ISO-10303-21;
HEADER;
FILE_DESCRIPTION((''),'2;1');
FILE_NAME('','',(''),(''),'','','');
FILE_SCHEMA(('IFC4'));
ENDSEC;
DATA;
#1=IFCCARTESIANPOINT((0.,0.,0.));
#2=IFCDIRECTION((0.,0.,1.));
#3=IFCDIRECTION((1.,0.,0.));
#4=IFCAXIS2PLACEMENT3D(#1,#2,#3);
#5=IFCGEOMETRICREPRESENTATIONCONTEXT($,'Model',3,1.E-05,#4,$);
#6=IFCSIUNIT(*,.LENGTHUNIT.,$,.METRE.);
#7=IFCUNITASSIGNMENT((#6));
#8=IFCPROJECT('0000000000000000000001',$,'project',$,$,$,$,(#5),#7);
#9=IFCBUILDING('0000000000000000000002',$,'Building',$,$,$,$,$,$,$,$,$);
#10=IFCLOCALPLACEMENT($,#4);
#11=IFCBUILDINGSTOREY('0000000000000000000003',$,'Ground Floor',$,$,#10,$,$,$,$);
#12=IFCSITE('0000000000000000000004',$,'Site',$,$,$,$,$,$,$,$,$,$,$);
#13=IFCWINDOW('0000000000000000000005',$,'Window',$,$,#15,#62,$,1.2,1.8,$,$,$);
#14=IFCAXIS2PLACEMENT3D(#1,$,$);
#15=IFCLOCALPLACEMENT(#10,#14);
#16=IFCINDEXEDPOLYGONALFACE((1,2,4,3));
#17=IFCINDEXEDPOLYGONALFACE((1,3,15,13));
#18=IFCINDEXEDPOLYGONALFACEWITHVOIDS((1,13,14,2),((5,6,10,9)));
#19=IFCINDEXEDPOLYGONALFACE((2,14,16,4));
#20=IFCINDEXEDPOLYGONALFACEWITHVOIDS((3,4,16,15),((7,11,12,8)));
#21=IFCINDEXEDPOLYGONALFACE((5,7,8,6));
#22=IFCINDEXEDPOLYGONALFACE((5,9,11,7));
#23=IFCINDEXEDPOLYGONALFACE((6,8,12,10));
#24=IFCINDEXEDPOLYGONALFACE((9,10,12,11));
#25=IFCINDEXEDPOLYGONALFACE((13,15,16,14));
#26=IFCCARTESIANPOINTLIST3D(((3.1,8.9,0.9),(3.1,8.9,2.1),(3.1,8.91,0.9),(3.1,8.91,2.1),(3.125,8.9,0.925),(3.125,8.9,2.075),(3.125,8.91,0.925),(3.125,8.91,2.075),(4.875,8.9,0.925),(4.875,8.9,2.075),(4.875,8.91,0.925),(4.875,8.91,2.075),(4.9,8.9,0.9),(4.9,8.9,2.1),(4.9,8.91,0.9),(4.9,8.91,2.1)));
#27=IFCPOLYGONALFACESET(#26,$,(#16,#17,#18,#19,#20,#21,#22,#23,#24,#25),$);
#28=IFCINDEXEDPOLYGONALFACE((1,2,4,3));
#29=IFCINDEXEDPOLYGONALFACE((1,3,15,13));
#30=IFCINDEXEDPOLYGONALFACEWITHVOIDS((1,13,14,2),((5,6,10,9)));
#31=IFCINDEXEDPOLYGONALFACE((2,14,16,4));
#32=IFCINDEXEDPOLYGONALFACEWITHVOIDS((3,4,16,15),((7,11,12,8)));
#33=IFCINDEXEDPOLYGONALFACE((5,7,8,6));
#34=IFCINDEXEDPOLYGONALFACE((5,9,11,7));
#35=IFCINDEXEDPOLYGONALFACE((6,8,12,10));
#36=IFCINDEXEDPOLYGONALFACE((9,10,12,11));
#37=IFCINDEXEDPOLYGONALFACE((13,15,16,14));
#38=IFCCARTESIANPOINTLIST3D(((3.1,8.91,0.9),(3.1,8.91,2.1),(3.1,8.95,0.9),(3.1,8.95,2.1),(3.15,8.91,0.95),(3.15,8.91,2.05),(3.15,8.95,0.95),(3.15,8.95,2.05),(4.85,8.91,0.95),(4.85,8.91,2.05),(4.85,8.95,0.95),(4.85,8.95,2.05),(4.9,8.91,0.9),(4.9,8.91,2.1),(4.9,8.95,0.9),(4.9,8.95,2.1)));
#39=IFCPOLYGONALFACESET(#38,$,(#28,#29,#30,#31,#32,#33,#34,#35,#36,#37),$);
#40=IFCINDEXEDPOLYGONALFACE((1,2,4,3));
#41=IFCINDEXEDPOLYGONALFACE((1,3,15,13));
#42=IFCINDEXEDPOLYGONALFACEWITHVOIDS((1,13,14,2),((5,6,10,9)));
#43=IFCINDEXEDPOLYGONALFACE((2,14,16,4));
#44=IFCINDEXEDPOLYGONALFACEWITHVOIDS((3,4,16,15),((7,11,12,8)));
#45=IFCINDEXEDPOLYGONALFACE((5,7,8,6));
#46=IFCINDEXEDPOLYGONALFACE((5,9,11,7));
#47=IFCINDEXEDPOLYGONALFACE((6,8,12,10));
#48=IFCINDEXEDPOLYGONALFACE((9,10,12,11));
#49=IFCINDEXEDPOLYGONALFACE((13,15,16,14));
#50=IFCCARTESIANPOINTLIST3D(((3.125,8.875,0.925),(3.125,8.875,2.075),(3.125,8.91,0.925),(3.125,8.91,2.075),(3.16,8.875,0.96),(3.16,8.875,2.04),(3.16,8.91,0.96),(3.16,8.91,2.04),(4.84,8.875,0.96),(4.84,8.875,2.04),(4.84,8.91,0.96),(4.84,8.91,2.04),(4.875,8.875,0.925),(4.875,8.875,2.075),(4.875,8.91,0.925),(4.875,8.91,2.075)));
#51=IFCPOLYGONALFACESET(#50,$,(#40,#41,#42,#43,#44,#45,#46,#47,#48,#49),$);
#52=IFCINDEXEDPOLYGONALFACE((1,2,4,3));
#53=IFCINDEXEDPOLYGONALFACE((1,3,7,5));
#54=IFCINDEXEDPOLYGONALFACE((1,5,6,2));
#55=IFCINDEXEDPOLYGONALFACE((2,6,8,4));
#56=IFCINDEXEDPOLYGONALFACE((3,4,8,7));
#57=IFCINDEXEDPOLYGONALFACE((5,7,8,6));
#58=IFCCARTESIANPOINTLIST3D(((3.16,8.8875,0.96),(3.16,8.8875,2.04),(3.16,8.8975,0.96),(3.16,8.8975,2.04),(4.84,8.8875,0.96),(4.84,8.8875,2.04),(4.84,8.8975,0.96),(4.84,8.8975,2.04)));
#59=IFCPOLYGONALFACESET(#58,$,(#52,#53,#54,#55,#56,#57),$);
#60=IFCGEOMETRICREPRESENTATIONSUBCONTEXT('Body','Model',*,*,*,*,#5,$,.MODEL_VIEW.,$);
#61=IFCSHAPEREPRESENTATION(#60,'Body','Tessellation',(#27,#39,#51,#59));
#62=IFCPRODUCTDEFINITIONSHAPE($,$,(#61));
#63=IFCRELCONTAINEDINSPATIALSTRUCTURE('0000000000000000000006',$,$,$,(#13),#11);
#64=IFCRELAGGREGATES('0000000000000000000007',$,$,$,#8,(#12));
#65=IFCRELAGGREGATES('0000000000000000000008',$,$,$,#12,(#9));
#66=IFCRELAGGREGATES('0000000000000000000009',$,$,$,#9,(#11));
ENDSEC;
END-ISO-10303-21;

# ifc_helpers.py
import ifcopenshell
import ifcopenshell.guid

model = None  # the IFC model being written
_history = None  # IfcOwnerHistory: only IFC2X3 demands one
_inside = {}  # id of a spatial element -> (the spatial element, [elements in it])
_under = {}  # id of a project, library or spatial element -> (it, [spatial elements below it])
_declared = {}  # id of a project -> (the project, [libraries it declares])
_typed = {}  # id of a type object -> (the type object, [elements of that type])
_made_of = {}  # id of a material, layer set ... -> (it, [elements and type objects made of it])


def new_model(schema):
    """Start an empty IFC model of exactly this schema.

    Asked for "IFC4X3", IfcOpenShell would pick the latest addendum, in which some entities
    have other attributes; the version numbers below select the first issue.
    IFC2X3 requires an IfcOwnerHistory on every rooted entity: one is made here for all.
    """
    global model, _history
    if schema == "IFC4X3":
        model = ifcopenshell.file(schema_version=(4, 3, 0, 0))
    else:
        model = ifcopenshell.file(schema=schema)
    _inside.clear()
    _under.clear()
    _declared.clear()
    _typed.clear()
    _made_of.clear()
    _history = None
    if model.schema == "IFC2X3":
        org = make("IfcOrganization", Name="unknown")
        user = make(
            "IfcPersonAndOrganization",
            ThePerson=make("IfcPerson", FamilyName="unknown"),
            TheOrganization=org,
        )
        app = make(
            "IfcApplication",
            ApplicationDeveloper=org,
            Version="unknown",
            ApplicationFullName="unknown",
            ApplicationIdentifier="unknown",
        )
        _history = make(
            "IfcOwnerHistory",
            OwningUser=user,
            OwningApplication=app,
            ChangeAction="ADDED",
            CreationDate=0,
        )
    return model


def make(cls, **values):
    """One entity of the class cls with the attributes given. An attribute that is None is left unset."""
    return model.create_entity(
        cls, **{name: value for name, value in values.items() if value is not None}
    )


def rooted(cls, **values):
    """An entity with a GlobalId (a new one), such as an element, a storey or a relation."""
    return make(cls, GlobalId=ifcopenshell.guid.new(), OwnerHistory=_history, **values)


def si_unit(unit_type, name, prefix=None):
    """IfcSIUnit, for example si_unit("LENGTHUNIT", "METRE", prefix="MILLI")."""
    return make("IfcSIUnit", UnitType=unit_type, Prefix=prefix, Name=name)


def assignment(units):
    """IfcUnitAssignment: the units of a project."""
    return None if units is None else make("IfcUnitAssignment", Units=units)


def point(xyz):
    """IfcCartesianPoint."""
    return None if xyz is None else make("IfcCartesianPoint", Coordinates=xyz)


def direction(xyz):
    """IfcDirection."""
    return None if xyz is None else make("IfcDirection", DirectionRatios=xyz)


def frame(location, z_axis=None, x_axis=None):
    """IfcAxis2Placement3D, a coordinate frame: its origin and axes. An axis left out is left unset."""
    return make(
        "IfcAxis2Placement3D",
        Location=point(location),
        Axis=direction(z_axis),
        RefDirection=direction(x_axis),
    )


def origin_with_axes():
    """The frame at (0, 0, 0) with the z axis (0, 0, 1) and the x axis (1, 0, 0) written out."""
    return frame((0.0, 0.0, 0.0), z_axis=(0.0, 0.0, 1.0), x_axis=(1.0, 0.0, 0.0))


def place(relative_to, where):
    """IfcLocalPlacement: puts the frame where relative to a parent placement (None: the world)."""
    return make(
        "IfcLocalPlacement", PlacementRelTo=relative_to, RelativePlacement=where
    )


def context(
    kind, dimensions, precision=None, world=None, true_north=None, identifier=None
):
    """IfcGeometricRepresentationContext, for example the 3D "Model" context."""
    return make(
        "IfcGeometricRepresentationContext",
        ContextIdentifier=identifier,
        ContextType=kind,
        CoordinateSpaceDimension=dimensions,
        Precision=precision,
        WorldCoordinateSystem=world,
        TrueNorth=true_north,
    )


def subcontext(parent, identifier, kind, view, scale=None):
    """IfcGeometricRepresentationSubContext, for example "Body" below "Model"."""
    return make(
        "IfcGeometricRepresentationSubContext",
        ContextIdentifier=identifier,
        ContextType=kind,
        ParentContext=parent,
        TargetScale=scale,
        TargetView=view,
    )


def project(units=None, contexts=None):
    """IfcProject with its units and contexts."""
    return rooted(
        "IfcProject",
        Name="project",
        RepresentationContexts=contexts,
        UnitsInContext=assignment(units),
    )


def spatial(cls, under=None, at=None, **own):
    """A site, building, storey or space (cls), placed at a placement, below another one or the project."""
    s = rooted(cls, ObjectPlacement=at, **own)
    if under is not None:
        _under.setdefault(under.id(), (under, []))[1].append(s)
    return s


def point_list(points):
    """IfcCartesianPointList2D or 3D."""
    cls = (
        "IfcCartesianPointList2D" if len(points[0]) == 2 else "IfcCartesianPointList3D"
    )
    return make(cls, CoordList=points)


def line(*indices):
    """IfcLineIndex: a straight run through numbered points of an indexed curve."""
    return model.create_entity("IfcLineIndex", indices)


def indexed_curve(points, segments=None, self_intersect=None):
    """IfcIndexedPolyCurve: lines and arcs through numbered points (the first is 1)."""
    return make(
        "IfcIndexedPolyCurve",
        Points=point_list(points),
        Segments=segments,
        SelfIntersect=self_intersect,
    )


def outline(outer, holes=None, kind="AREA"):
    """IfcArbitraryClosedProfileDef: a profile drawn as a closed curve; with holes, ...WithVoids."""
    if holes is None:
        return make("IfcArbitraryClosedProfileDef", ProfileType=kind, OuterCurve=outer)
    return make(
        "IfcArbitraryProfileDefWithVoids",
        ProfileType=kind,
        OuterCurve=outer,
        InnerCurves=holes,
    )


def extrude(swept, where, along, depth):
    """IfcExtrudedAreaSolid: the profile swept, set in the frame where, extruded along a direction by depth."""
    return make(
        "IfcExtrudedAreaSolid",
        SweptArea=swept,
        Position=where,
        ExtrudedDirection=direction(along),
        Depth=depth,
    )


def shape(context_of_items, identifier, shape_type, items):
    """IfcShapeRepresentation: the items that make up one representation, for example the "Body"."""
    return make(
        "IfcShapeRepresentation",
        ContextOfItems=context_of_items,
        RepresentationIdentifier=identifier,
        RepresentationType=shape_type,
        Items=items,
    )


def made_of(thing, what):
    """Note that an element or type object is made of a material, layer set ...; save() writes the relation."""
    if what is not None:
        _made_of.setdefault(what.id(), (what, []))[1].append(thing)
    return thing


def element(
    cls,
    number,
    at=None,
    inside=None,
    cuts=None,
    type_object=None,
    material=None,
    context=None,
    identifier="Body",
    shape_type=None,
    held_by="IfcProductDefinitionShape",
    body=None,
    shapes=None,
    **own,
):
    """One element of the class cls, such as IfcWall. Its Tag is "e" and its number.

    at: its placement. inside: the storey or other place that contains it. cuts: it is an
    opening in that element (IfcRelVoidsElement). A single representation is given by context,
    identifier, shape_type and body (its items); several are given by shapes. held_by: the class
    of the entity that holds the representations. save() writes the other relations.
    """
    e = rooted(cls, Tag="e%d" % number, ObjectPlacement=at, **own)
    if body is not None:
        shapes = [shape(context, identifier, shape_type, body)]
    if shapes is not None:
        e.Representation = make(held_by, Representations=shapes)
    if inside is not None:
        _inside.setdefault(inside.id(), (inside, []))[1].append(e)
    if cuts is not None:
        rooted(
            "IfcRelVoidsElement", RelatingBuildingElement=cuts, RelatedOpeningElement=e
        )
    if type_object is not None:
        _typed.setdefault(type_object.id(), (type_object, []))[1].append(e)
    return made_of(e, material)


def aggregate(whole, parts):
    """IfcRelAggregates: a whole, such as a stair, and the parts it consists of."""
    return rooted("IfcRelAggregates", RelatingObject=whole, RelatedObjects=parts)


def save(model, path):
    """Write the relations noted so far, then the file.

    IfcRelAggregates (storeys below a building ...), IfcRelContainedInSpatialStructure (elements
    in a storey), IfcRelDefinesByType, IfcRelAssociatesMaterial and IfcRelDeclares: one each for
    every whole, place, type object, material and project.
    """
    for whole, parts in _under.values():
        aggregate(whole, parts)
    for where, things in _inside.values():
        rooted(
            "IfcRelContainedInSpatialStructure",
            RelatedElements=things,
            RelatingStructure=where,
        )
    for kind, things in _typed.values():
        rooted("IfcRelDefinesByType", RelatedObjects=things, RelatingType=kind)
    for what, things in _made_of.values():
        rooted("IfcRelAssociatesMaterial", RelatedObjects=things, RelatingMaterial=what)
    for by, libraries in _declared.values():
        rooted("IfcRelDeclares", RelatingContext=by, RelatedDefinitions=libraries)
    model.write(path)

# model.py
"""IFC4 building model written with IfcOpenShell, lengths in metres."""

from ifc_helpers import new_model, si_unit, frame, origin_with_axes, place, context, subcontext, project, spatial, line, indexed_curve, outline, extrude, element, save


model = new_model("IFC4")

# Units and contexts
model_context = context("Model", 3, precision=1e-05, world=origin_with_axes())
body_context = subcontext(model_context, "Body", "Model", "MODEL_VIEW")
ifc_project = project(units=[si_unit("LENGTHUNIT", "METRE")], contexts=[model_context])

# Site, building, storey
site = spatial("IfcSite", under=ifc_project, Name="Site")
building = spatial("IfcBuilding", under=site, Name="Building")
storey_placement = place(None, origin_with_axes())
storey = spatial("IfcBuildingStorey", under=building, at=storey_placement, Name="Ground Floor")

# Window
window_placement = place(storey_placement, frame((4.9, 9.0, 0.9), z_axis=(0.0, 0.0, 1.0), x_axis=(-1.0, 0.0, 0.0)))
element("IfcWindow", 1, at=window_placement, inside=storey, Name="Window", OverallHeight=1.2, OverallWidth=1.8, context=body_context, shape_type="SweptSolid", body=[
    extrude(outline(indexed_curve([(0.0, 0.0), (1.8, 0.0), (1.8, 1.2), (0.0, 1.2)], segments=[line(1, 2, 3, 4, 1)]), holes=[indexed_curve([(0.025, 0.025), (1.775, 0.025), (1.775, 1.175), (0.025, 1.175)], segments=[line(1, 2, 3, 4, 1)])]), frame((0.0, 0.09, 0.0), z_axis=(0.0, -1.0, 0.0), x_axis=(1.0, 0.0, 0.0)), (0.0, 0.0, -1.0), 0.01),
    extrude(outline(indexed_curve([(0.0, 0.0), (1.8, 0.0), (1.8, 1.2), (0.0, 1.2)], segments=[line(1, 2, 3, 4, 1)]), holes=[indexed_curve([(0.05, 0.05), (1.75, 0.05), (1.75, 1.15), (0.05, 1.15)], segments=[line(1, 2, 3, 4, 1)])]), frame((0.0, 0.05, 0.0), z_axis=(0.0, -1.0, 0.0), x_axis=(1.0, 0.0, 0.0)), (0.0, 0.0, -1.0), 0.04),
    extrude(outline(indexed_curve([(0.0, 0.0), (1.75, 0.0), (1.75, 1.15), (0.0, 1.15)], segments=[line(1, 2, 3, 4, 1)]), holes=[indexed_curve([(0.035, 0.035), (1.715, 0.035), (1.715, 1.115), (0.035, 1.115)], segments=[line(1, 2, 3, 4, 1)])]), frame((0.025, 0.09, 0.025), z_axis=(0.0, -1.0, 0.0), x_axis=(1.0, 0.0, 0.0)), (0.0, 0.0, -1.0), 0.035),
    extrude(outline(indexed_curve([(0.035, 0.035), (1.715, 0.035), (1.715, 1.115), (0.035, 1.115)], segments=[line(1, 2, 3, 4, 1)])), frame((0.025, 0.1025, 0.025), z_axis=(0.0, -1.0, 0.0), x_axis=(1.0, 0.0, 0.0)), (0.0, 0.0, -1.0), 0.01),
])

save(model, "model.ifc")
